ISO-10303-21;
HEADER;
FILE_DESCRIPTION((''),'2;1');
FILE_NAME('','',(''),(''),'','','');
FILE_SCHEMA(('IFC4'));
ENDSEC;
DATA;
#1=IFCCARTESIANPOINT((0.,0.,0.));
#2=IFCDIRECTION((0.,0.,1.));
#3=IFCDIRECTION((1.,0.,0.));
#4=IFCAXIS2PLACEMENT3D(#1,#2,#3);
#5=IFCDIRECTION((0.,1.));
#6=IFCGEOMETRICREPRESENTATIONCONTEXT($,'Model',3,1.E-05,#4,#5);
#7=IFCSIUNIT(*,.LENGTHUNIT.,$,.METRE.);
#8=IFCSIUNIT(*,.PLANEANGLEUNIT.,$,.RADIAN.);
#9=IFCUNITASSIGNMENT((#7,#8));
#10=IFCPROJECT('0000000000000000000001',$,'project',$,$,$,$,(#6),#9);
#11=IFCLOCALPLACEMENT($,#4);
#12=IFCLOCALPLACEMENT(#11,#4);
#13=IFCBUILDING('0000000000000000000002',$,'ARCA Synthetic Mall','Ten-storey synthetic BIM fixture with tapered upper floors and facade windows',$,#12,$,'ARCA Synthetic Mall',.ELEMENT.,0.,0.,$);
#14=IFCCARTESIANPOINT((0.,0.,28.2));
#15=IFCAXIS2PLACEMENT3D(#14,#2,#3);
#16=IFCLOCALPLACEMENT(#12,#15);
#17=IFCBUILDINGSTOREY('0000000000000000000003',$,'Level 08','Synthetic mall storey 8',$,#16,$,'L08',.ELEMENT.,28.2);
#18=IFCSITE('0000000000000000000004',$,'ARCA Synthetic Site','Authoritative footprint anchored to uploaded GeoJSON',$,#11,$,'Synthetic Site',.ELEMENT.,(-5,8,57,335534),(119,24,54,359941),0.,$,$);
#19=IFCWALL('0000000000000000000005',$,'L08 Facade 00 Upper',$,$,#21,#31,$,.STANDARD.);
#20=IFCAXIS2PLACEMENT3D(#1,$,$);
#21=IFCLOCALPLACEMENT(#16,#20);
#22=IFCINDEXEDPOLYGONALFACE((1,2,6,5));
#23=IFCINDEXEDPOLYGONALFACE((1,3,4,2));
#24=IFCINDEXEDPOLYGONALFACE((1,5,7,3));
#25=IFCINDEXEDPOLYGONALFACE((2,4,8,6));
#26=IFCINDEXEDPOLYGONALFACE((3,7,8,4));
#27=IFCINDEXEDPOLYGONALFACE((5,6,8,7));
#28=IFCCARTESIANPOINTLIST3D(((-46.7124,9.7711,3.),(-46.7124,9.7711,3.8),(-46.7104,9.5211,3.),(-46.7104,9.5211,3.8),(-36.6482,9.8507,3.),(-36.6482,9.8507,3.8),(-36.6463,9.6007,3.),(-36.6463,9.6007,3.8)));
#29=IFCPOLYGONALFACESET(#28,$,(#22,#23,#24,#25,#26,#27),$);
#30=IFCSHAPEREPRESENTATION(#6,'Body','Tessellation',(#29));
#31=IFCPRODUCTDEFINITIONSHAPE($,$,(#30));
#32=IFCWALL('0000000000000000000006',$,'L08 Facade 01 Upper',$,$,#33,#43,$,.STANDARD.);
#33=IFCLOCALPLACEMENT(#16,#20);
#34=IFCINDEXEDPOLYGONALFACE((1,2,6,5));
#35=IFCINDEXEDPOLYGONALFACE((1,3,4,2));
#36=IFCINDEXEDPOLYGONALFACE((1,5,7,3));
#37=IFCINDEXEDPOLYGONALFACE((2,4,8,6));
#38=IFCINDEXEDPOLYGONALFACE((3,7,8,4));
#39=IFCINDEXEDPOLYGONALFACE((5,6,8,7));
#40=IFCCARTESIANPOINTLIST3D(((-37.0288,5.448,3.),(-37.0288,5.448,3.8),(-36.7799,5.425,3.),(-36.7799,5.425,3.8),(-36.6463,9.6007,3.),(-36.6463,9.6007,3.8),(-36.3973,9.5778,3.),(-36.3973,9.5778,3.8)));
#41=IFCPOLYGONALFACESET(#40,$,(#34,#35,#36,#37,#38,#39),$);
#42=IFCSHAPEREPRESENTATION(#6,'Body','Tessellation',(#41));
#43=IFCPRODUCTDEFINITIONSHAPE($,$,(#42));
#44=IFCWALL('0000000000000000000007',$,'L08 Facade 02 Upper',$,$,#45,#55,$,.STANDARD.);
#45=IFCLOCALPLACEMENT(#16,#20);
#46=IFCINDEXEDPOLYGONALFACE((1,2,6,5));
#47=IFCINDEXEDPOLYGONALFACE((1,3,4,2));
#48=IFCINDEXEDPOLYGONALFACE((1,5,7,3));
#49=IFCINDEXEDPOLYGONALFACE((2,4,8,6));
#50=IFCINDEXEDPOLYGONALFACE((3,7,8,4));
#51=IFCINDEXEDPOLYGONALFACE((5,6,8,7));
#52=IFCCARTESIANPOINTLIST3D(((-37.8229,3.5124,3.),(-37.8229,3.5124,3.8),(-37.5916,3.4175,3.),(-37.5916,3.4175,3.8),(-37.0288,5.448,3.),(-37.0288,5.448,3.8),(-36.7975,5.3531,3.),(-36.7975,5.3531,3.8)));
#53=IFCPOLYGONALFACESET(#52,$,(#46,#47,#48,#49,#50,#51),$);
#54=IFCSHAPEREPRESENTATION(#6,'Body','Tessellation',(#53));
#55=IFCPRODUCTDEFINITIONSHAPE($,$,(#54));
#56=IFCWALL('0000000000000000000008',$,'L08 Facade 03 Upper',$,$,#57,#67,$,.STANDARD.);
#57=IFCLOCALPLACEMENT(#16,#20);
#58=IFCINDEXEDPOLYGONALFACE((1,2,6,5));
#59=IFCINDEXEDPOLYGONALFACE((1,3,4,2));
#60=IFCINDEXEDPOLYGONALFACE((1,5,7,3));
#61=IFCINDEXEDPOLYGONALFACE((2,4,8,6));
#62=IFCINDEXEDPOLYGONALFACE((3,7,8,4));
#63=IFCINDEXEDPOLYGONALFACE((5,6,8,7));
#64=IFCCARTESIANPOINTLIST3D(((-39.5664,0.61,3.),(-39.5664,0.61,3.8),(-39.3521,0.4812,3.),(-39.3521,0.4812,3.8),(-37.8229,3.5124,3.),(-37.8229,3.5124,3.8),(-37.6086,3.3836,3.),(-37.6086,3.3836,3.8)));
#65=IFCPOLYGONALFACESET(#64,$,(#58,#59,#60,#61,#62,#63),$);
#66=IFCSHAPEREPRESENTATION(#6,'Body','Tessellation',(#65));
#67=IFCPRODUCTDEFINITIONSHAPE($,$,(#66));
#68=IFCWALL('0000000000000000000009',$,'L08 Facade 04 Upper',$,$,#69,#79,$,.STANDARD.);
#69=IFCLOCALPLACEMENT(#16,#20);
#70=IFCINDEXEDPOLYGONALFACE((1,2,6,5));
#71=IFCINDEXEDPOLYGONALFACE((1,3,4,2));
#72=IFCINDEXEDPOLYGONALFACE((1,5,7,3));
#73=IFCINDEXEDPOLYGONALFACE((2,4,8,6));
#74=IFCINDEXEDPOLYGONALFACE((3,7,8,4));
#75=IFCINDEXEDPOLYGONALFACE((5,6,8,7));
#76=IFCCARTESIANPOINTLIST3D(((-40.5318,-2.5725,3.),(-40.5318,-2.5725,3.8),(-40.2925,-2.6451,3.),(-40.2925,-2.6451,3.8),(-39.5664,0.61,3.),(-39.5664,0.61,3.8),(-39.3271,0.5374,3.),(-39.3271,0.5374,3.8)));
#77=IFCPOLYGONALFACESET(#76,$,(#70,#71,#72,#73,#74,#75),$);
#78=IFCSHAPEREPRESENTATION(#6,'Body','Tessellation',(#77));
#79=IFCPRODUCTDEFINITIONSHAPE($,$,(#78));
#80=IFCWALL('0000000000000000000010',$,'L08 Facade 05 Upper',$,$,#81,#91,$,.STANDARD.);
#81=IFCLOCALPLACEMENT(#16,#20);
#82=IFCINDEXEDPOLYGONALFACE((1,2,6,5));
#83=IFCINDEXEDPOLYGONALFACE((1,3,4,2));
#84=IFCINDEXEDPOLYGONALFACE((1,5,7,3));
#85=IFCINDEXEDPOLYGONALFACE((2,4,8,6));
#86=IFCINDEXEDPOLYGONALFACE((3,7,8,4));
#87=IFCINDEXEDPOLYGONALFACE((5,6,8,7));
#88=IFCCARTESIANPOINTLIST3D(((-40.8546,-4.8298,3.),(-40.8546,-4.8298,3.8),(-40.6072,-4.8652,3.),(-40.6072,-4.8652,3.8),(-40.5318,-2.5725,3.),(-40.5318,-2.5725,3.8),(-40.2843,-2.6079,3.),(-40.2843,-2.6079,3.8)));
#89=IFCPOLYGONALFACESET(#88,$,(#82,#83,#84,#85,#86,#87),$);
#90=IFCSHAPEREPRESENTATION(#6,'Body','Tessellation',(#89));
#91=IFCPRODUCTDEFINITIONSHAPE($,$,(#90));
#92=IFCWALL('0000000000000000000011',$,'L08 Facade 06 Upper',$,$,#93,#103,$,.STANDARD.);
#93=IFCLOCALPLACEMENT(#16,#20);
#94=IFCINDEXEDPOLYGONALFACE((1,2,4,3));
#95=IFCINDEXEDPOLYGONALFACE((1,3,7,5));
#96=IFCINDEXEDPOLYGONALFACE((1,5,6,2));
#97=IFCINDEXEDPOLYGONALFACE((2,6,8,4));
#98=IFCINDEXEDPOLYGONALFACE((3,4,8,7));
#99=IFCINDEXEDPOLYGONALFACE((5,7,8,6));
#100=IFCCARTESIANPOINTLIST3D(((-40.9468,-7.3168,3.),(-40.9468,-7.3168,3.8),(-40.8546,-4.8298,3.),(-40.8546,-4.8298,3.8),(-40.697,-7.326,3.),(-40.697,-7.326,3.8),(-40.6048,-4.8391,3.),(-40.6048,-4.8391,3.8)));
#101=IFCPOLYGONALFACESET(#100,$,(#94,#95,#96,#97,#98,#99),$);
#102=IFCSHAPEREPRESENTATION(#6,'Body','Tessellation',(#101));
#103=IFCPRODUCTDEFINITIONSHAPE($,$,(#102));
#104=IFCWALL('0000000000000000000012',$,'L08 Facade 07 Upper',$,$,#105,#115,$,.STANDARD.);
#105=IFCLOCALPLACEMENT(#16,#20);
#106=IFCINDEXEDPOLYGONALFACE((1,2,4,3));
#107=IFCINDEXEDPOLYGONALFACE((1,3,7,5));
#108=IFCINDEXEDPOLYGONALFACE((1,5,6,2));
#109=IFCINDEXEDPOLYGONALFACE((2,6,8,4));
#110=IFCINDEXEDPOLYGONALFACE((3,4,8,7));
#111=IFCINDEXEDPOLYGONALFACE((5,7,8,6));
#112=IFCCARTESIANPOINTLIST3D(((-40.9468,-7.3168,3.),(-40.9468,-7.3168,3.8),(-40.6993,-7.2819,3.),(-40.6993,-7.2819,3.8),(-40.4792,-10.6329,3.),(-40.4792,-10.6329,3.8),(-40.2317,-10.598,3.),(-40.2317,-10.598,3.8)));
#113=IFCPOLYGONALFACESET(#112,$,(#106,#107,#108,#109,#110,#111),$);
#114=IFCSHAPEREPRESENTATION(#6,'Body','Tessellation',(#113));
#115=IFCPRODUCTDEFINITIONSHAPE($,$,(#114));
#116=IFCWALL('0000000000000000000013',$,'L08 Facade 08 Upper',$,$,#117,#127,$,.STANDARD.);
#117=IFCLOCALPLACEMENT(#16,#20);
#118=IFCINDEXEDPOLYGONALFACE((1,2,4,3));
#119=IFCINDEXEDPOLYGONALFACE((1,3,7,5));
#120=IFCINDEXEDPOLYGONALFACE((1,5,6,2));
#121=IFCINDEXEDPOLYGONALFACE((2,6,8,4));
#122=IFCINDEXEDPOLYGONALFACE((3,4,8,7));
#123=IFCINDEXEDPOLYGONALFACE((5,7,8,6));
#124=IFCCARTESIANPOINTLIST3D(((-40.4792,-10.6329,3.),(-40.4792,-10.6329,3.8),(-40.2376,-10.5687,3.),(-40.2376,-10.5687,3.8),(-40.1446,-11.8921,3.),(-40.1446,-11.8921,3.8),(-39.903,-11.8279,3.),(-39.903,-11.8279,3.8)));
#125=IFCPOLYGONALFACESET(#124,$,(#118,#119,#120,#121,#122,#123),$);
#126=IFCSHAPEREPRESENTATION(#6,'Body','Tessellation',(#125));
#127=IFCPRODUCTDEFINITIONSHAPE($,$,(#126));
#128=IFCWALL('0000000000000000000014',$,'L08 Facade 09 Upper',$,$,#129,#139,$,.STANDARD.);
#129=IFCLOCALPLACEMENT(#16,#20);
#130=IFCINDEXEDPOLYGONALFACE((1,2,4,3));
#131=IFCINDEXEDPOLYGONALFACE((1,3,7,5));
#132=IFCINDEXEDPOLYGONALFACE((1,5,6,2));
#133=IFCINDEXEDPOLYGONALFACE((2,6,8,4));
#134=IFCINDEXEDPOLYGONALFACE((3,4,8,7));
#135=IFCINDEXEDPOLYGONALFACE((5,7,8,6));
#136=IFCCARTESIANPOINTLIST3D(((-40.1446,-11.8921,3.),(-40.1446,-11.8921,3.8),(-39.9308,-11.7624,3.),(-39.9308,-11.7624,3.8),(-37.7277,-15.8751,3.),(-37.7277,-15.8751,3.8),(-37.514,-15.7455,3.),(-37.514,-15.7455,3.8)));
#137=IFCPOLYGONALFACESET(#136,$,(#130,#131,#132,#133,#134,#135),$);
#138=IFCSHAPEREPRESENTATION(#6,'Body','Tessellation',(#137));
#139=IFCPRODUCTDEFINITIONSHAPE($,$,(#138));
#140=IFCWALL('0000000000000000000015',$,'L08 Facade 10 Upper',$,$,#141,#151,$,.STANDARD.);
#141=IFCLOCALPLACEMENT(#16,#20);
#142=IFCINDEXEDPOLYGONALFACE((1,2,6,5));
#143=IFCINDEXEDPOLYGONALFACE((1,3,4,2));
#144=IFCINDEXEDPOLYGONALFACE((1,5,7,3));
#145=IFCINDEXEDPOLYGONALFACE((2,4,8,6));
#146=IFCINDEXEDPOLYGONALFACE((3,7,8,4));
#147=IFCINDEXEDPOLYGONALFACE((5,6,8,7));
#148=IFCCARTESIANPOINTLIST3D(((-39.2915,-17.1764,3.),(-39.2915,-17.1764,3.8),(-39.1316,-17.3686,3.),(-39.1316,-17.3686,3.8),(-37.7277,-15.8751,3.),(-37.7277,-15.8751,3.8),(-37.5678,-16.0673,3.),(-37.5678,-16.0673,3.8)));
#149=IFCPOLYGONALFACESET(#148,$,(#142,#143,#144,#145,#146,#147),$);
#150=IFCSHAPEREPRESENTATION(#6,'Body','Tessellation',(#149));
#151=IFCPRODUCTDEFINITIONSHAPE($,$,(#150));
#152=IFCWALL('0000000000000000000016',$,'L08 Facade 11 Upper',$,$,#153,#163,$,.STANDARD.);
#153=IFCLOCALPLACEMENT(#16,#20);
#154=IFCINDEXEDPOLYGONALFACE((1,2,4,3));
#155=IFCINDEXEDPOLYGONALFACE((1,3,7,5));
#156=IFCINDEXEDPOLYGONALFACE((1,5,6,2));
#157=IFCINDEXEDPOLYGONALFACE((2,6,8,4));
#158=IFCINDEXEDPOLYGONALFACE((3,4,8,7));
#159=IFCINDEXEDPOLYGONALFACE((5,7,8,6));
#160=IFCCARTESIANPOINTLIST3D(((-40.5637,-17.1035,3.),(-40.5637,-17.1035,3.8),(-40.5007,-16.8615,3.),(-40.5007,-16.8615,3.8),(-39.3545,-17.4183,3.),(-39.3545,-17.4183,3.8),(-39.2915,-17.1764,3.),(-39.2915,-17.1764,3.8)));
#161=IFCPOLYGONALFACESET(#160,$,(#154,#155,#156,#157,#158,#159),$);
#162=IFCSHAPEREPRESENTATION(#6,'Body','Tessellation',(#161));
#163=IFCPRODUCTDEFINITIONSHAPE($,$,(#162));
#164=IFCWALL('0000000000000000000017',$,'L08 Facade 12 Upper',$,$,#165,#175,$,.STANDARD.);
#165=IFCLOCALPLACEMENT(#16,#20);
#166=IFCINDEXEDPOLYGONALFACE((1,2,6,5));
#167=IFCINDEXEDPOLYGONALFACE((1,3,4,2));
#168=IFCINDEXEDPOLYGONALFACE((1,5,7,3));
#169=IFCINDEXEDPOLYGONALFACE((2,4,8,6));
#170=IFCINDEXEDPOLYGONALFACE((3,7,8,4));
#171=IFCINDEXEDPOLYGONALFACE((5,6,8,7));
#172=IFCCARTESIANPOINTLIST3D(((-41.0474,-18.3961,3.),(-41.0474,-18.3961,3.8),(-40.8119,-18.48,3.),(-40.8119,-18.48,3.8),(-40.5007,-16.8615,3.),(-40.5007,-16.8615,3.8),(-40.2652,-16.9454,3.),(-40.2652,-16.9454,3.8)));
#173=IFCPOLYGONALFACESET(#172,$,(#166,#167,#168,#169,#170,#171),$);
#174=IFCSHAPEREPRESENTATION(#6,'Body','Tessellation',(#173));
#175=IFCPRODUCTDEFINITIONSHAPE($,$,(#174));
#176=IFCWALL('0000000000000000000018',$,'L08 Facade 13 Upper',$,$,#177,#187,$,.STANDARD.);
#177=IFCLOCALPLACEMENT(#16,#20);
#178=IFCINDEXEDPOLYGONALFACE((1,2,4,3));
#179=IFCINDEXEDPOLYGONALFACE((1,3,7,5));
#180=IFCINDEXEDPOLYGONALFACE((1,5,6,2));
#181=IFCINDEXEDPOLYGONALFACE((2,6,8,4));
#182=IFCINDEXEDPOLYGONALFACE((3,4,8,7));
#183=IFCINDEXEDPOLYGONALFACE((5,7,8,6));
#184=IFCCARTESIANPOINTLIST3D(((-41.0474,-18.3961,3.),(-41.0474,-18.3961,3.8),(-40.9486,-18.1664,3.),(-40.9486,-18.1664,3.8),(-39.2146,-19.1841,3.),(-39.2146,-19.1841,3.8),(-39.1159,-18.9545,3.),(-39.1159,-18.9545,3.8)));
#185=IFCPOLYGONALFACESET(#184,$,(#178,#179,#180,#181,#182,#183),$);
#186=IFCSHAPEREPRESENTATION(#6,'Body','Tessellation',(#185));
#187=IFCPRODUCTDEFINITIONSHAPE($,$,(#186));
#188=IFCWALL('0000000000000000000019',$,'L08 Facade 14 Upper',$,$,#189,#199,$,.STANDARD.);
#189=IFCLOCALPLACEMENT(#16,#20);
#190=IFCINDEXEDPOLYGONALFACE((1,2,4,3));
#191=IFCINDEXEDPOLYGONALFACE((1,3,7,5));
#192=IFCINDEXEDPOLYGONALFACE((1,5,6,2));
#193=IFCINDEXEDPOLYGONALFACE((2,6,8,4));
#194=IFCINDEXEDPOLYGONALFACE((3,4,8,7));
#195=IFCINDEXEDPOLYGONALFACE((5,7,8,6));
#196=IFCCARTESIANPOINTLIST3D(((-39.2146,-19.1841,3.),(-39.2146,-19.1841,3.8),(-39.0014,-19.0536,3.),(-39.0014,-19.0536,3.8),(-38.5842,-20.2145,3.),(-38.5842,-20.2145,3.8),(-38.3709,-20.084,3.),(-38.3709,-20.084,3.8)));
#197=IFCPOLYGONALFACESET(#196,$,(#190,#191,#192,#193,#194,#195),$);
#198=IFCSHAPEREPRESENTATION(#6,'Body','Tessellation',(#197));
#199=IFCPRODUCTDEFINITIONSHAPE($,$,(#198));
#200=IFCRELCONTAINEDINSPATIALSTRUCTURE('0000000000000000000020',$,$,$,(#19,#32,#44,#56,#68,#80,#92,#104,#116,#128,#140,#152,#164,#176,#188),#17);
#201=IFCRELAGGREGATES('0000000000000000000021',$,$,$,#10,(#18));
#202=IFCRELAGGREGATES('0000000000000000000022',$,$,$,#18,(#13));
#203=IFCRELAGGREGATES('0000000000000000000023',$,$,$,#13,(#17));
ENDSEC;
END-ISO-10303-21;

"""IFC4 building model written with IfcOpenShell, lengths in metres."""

from ifc_helpers import new_model, si_unit, direction, frame, origin_with_axes, place, context, project, spatial, polyline, outline, extrude, element, save


model = new_model("IFC4")

# Units and contexts
model_context = context("Model", 3, precision=1e-05, world=origin_with_axes(), true_north=direction((0.0, 1.0)))
ifc_project = project(units=[si_unit("LENGTHUNIT", "METRE"), si_unit("PLANEANGLEUNIT", "RADIAN")], contexts=[model_context])

# Site, building, storey
site_placement = place(None, origin_with_axes())
site = spatial("IfcSite", under=ifc_project, at=site_placement, Name="ARCA Synthetic Site", Description="Authoritative footprint anchored to uploaded GeoJSON", LongName="Synthetic Site", CompositionType="ELEMENT", RefLatitude=(-5, 8, 57, 335534), RefLongitude=(119, 24, 54, 359941), RefElevation=0.0)
building_placement = place(site_placement, origin_with_axes())
building = spatial("IfcBuilding", under=site, at=building_placement, Name="ARCA Synthetic Mall", Description="Ten-storey synthetic BIM fixture with tapered upper floors and facade windows", LongName="ARCA Synthetic Mall", CompositionType="ELEMENT", ElevationOfRefHeight=0.0, ElevationOfTerrain=0.0)
storey_placement = place(building_placement, frame((0.0, 0.0, 28.2), z_axis=(0.0, 0.0, 1.0), x_axis=(1.0, 0.0, 0.0)))
storey = spatial("IfcBuildingStorey", under=building, at=storey_placement, Name="Level 08", Description="Synthetic mall storey 8", LongName="L08", CompositionType="ELEMENT", Elevation=28.2)

# Walls
wall_1_placement = place(storey_placement, frame((0.0, 0.0, 3.0), z_axis=(0.0, 0.0, 1.0), x_axis=(1.0, 0.0, 0.0)))
element("IfcWall", 1, at=wall_1_placement, inside=storey, Name="L08 Facade 00 Upper", PredefinedType="STANDARD", context=model_context, shape_type="SweptSolid", body=[
    extrude(outline(polyline([(-46.7104, 9.5211), (-36.6463, 9.6007), (-36.6482, 9.8507), (-46.7124, 9.7711), (-46.7104, 9.5211)])), origin_with_axes(), (0.0, 0.0, 1.0), 0.8),
])
wall_2_placement = place(storey_placement, frame((0.0, 0.0, 3.0), z_axis=(0.0, 0.0, 1.0), x_axis=(1.0, 0.0, 0.0)))
element("IfcWall", 2, at=wall_2_placement, inside=storey, Name="L08 Facade 01 Upper", PredefinedType="STANDARD", context=model_context, shape_type="SweptSolid", body=[
    extrude(outline(polyline([(-36.6463, 9.6007), (-37.0288, 5.448), (-36.7799, 5.425), (-36.3973, 9.5778), (-36.6463, 9.6007)])), origin_with_axes(), (0.0, 0.0, 1.0), 0.8),
])
wall_3_placement = place(storey_placement, frame((0.0, 0.0, 3.0), z_axis=(0.0, 0.0, 1.0), x_axis=(1.0, 0.0, 0.0)))
element("IfcWall", 3, at=wall_3_placement, inside=storey, Name="L08 Facade 02 Upper", PredefinedType="STANDARD", context=model_context, shape_type="SweptSolid", body=[
    extrude(outline(polyline([(-37.0288, 5.448), (-37.8229, 3.5124), (-37.5916, 3.4175), (-36.7975, 5.3531), (-37.0288, 5.448)])), origin_with_axes(), (0.0, 0.0, 1.0), 0.8),
])
wall_4_placement = place(storey_placement, frame((0.0, 0.0, 3.0), z_axis=(0.0, 0.0, 1.0), x_axis=(1.0, 0.0, 0.0)))
element("IfcWall", 4, at=wall_4_placement, inside=storey, Name="L08 Facade 03 Upper", PredefinedType="STANDARD", context=model_context, shape_type="SweptSolid", body=[
    extrude(outline(polyline([(-37.8229, 3.5124), (-39.5664, 0.61), (-39.3521, 0.4812), (-37.6086, 3.3836), (-37.8229, 3.5124)])), origin_with_axes(), (0.0, 0.0, 1.0), 0.8),
])
wall_5_placement = place(storey_placement, frame((0.0, 0.0, 3.0), z_axis=(0.0, 0.0, 1.0), x_axis=(1.0, 0.0, 0.0)))
element("IfcWall", 5, at=wall_5_placement, inside=storey, Name="L08 Facade 04 Upper", PredefinedType="STANDARD", context=model_context, shape_type="SweptSolid", body=[
    extrude(outline(polyline([(-39.5664, 0.61), (-40.5318, -2.5725), (-40.2925, -2.6451), (-39.3271, 0.5374), (-39.5664, 0.61)])), origin_with_axes(), (0.0, 0.0, 1.0), 0.8),
])
wall_6_placement = place(storey_placement, frame((0.0, 0.0, 3.0), z_axis=(0.0, 0.0, 1.0), x_axis=(1.0, 0.0, 0.0)))
element("IfcWall", 6, at=wall_6_placement, inside=storey, Name="L08 Facade 05 Upper", PredefinedType="STANDARD", context=model_context, shape_type="SweptSolid", body=[
    extrude(outline(polyline([(-40.5318, -2.5725), (-40.8546, -4.8298), (-40.6072, -4.8652), (-40.2843, -2.6079), (-40.5318, -2.5725)])), origin_with_axes(), (0.0, 0.0, 1.0), 0.8),
])
wall_7_placement = place(storey_placement, frame((0.0, 0.0, 3.0), z_axis=(0.0, 0.0, 1.0), x_axis=(1.0, 0.0, 0.0)))
element("IfcWall", 7, at=wall_7_placement, inside=storey, Name="L08 Facade 06 Upper", PredefinedType="STANDARD", context=model_context, shape_type="SweptSolid", body=[
    extrude(outline(polyline([(-40.8546, -4.8298), (-40.9468, -7.3168), (-40.697, -7.326), (-40.6048, -4.8391), (-40.8546, -4.8298)])), origin_with_axes(), (0.0, 0.0, 1.0), 0.8),
])
wall_8_placement = place(storey_placement, frame((0.0, 0.0, 3.0), z_axis=(0.0, 0.0, 1.0), x_axis=(1.0, 0.0, 0.0)))
element("IfcWall", 8, at=wall_8_placement, inside=storey, Name="L08 Facade 07 Upper", PredefinedType="STANDARD", context=model_context, shape_type="SweptSolid", body=[
    extrude(outline(polyline([(-40.9468, -7.3168), (-40.4792, -10.6329), (-40.2317, -10.598), (-40.6993, -7.2819), (-40.9468, -7.3168)])), origin_with_axes(), (0.0, 0.0, 1.0), 0.8),
])
wall_9_placement = place(storey_placement, frame((0.0, 0.0, 3.0), z_axis=(0.0, 0.0, 1.0), x_axis=(1.0, 0.0, 0.0)))
element("IfcWall", 9, at=wall_9_placement, inside=storey, Name="L08 Facade 08 Upper", PredefinedType="STANDARD", context=model_context, shape_type="SweptSolid", body=[
    extrude(outline(polyline([(-40.4792, -10.6329), (-40.1446, -11.8921), (-39.903, -11.8279), (-40.2376, -10.5687), (-40.4792, -10.6329)])), origin_with_axes(), (0.0, 0.0, 1.0), 0.8),
])
wall_10_placement = place(storey_placement, frame((0.0, 0.0, 3.0), z_axis=(0.0, 0.0, 1.0), x_axis=(1.0, 0.0, 0.0)))
element("IfcWall", 10, at=wall_10_placement, inside=storey, Name="L08 Facade 09 Upper", PredefinedType="STANDARD", context=model_context, shape_type="SweptSolid", body=[
    extrude(outline(polyline([(-40.1446, -11.8921), (-37.7277, -15.8751), (-37.514, -15.7455), (-39.9308, -11.7624), (-40.1446, -11.8921)])), origin_with_axes(), (0.0, 0.0, 1.0), 0.8),
])
wall_11_placement = place(storey_placement, frame((0.0, 0.0, 3.0), z_axis=(0.0, 0.0, 1.0), x_axis=(1.0, 0.0, 0.0)))
element("IfcWall", 11, at=wall_11_placement, inside=storey, Name="L08 Facade 10 Upper", PredefinedType="STANDARD", context=model_context, shape_type="SweptSolid", body=[
    extrude(outline(polyline([(-37.7277, -15.8751), (-39.2915, -17.1764), (-39.1316, -17.3686), (-37.5678, -16.0673), (-37.7277, -15.8751)])), origin_with_axes(), (0.0, 0.0, 1.0), 0.8),
])
wall_12_placement = place(storey_placement, frame((0.0, 0.0, 3.0), z_axis=(0.0, 0.0, 1.0), x_axis=(1.0, 0.0, 0.0)))
element("IfcWall", 12, at=wall_12_placement, inside=storey, Name="L08 Facade 11 Upper", PredefinedType="STANDARD", context=model_context, shape_type="SweptSolid", body=[
    extrude(outline(polyline([(-39.2915, -17.1764), (-40.5007, -16.8615), (-40.5637, -17.1035), (-39.3545, -17.4183), (-39.2915, -17.1764)])), origin_with_axes(), (0.0, 0.0, 1.0), 0.8),
])
wall_13_placement = place(storey_placement, frame((0.0, 0.0, 3.0), z_axis=(0.0, 0.0, 1.0), x_axis=(1.0, 0.0, 0.0)))
element("IfcWall", 13, at=wall_13_placement, inside=storey, Name="L08 Facade 12 Upper", PredefinedType="STANDARD", context=model_context, shape_type="SweptSolid", body=[
    extrude(outline(polyline([(-40.5007, -16.8615), (-41.0474, -18.3961), (-40.8119, -18.48), (-40.2652, -16.9454), (-40.5007, -16.8615)])), origin_with_axes(), (0.0, 0.0, 1.0), 0.8),
])
wall_14_placement = place(storey_placement, frame((0.0, 0.0, 3.0), z_axis=(0.0, 0.0, 1.0), x_axis=(1.0, 0.0, 0.0)))
element("IfcWall", 14, at=wall_14_placement, inside=storey, Name="L08 Facade 13 Upper", PredefinedType="STANDARD", context=model_context, shape_type="SweptSolid", body=[
    extrude(outline(polyline([(-41.0474, -18.3961), (-39.2146, -19.1841), (-39.1159, -18.9545), (-40.9486, -18.1664), (-41.0474, -18.3961)])), origin_with_axes(), (0.0, 0.0, 1.0), 0.8),
])
wall_15_placement = place(storey_placement, frame((0.0, 0.0, 3.0), z_axis=(0.0, 0.0, 1.0), x_axis=(1.0, 0.0, 0.0)))
element("IfcWall", 15, at=wall_15_placement, inside=storey, Name="L08 Facade 14 Upper", PredefinedType="STANDARD", context=model_context, shape_type="SweptSolid", body=[
    extrude(outline(polyline([(-39.2146, -19.1841), (-38.5842, -20.2145), (-38.3709, -20.084), (-39.0014, -19.0536), (-39.2146, -19.1841)])), origin_with_axes(), (0.0, 0.0, 1.0), 0.8),
])

save(model, "model.ifc")
